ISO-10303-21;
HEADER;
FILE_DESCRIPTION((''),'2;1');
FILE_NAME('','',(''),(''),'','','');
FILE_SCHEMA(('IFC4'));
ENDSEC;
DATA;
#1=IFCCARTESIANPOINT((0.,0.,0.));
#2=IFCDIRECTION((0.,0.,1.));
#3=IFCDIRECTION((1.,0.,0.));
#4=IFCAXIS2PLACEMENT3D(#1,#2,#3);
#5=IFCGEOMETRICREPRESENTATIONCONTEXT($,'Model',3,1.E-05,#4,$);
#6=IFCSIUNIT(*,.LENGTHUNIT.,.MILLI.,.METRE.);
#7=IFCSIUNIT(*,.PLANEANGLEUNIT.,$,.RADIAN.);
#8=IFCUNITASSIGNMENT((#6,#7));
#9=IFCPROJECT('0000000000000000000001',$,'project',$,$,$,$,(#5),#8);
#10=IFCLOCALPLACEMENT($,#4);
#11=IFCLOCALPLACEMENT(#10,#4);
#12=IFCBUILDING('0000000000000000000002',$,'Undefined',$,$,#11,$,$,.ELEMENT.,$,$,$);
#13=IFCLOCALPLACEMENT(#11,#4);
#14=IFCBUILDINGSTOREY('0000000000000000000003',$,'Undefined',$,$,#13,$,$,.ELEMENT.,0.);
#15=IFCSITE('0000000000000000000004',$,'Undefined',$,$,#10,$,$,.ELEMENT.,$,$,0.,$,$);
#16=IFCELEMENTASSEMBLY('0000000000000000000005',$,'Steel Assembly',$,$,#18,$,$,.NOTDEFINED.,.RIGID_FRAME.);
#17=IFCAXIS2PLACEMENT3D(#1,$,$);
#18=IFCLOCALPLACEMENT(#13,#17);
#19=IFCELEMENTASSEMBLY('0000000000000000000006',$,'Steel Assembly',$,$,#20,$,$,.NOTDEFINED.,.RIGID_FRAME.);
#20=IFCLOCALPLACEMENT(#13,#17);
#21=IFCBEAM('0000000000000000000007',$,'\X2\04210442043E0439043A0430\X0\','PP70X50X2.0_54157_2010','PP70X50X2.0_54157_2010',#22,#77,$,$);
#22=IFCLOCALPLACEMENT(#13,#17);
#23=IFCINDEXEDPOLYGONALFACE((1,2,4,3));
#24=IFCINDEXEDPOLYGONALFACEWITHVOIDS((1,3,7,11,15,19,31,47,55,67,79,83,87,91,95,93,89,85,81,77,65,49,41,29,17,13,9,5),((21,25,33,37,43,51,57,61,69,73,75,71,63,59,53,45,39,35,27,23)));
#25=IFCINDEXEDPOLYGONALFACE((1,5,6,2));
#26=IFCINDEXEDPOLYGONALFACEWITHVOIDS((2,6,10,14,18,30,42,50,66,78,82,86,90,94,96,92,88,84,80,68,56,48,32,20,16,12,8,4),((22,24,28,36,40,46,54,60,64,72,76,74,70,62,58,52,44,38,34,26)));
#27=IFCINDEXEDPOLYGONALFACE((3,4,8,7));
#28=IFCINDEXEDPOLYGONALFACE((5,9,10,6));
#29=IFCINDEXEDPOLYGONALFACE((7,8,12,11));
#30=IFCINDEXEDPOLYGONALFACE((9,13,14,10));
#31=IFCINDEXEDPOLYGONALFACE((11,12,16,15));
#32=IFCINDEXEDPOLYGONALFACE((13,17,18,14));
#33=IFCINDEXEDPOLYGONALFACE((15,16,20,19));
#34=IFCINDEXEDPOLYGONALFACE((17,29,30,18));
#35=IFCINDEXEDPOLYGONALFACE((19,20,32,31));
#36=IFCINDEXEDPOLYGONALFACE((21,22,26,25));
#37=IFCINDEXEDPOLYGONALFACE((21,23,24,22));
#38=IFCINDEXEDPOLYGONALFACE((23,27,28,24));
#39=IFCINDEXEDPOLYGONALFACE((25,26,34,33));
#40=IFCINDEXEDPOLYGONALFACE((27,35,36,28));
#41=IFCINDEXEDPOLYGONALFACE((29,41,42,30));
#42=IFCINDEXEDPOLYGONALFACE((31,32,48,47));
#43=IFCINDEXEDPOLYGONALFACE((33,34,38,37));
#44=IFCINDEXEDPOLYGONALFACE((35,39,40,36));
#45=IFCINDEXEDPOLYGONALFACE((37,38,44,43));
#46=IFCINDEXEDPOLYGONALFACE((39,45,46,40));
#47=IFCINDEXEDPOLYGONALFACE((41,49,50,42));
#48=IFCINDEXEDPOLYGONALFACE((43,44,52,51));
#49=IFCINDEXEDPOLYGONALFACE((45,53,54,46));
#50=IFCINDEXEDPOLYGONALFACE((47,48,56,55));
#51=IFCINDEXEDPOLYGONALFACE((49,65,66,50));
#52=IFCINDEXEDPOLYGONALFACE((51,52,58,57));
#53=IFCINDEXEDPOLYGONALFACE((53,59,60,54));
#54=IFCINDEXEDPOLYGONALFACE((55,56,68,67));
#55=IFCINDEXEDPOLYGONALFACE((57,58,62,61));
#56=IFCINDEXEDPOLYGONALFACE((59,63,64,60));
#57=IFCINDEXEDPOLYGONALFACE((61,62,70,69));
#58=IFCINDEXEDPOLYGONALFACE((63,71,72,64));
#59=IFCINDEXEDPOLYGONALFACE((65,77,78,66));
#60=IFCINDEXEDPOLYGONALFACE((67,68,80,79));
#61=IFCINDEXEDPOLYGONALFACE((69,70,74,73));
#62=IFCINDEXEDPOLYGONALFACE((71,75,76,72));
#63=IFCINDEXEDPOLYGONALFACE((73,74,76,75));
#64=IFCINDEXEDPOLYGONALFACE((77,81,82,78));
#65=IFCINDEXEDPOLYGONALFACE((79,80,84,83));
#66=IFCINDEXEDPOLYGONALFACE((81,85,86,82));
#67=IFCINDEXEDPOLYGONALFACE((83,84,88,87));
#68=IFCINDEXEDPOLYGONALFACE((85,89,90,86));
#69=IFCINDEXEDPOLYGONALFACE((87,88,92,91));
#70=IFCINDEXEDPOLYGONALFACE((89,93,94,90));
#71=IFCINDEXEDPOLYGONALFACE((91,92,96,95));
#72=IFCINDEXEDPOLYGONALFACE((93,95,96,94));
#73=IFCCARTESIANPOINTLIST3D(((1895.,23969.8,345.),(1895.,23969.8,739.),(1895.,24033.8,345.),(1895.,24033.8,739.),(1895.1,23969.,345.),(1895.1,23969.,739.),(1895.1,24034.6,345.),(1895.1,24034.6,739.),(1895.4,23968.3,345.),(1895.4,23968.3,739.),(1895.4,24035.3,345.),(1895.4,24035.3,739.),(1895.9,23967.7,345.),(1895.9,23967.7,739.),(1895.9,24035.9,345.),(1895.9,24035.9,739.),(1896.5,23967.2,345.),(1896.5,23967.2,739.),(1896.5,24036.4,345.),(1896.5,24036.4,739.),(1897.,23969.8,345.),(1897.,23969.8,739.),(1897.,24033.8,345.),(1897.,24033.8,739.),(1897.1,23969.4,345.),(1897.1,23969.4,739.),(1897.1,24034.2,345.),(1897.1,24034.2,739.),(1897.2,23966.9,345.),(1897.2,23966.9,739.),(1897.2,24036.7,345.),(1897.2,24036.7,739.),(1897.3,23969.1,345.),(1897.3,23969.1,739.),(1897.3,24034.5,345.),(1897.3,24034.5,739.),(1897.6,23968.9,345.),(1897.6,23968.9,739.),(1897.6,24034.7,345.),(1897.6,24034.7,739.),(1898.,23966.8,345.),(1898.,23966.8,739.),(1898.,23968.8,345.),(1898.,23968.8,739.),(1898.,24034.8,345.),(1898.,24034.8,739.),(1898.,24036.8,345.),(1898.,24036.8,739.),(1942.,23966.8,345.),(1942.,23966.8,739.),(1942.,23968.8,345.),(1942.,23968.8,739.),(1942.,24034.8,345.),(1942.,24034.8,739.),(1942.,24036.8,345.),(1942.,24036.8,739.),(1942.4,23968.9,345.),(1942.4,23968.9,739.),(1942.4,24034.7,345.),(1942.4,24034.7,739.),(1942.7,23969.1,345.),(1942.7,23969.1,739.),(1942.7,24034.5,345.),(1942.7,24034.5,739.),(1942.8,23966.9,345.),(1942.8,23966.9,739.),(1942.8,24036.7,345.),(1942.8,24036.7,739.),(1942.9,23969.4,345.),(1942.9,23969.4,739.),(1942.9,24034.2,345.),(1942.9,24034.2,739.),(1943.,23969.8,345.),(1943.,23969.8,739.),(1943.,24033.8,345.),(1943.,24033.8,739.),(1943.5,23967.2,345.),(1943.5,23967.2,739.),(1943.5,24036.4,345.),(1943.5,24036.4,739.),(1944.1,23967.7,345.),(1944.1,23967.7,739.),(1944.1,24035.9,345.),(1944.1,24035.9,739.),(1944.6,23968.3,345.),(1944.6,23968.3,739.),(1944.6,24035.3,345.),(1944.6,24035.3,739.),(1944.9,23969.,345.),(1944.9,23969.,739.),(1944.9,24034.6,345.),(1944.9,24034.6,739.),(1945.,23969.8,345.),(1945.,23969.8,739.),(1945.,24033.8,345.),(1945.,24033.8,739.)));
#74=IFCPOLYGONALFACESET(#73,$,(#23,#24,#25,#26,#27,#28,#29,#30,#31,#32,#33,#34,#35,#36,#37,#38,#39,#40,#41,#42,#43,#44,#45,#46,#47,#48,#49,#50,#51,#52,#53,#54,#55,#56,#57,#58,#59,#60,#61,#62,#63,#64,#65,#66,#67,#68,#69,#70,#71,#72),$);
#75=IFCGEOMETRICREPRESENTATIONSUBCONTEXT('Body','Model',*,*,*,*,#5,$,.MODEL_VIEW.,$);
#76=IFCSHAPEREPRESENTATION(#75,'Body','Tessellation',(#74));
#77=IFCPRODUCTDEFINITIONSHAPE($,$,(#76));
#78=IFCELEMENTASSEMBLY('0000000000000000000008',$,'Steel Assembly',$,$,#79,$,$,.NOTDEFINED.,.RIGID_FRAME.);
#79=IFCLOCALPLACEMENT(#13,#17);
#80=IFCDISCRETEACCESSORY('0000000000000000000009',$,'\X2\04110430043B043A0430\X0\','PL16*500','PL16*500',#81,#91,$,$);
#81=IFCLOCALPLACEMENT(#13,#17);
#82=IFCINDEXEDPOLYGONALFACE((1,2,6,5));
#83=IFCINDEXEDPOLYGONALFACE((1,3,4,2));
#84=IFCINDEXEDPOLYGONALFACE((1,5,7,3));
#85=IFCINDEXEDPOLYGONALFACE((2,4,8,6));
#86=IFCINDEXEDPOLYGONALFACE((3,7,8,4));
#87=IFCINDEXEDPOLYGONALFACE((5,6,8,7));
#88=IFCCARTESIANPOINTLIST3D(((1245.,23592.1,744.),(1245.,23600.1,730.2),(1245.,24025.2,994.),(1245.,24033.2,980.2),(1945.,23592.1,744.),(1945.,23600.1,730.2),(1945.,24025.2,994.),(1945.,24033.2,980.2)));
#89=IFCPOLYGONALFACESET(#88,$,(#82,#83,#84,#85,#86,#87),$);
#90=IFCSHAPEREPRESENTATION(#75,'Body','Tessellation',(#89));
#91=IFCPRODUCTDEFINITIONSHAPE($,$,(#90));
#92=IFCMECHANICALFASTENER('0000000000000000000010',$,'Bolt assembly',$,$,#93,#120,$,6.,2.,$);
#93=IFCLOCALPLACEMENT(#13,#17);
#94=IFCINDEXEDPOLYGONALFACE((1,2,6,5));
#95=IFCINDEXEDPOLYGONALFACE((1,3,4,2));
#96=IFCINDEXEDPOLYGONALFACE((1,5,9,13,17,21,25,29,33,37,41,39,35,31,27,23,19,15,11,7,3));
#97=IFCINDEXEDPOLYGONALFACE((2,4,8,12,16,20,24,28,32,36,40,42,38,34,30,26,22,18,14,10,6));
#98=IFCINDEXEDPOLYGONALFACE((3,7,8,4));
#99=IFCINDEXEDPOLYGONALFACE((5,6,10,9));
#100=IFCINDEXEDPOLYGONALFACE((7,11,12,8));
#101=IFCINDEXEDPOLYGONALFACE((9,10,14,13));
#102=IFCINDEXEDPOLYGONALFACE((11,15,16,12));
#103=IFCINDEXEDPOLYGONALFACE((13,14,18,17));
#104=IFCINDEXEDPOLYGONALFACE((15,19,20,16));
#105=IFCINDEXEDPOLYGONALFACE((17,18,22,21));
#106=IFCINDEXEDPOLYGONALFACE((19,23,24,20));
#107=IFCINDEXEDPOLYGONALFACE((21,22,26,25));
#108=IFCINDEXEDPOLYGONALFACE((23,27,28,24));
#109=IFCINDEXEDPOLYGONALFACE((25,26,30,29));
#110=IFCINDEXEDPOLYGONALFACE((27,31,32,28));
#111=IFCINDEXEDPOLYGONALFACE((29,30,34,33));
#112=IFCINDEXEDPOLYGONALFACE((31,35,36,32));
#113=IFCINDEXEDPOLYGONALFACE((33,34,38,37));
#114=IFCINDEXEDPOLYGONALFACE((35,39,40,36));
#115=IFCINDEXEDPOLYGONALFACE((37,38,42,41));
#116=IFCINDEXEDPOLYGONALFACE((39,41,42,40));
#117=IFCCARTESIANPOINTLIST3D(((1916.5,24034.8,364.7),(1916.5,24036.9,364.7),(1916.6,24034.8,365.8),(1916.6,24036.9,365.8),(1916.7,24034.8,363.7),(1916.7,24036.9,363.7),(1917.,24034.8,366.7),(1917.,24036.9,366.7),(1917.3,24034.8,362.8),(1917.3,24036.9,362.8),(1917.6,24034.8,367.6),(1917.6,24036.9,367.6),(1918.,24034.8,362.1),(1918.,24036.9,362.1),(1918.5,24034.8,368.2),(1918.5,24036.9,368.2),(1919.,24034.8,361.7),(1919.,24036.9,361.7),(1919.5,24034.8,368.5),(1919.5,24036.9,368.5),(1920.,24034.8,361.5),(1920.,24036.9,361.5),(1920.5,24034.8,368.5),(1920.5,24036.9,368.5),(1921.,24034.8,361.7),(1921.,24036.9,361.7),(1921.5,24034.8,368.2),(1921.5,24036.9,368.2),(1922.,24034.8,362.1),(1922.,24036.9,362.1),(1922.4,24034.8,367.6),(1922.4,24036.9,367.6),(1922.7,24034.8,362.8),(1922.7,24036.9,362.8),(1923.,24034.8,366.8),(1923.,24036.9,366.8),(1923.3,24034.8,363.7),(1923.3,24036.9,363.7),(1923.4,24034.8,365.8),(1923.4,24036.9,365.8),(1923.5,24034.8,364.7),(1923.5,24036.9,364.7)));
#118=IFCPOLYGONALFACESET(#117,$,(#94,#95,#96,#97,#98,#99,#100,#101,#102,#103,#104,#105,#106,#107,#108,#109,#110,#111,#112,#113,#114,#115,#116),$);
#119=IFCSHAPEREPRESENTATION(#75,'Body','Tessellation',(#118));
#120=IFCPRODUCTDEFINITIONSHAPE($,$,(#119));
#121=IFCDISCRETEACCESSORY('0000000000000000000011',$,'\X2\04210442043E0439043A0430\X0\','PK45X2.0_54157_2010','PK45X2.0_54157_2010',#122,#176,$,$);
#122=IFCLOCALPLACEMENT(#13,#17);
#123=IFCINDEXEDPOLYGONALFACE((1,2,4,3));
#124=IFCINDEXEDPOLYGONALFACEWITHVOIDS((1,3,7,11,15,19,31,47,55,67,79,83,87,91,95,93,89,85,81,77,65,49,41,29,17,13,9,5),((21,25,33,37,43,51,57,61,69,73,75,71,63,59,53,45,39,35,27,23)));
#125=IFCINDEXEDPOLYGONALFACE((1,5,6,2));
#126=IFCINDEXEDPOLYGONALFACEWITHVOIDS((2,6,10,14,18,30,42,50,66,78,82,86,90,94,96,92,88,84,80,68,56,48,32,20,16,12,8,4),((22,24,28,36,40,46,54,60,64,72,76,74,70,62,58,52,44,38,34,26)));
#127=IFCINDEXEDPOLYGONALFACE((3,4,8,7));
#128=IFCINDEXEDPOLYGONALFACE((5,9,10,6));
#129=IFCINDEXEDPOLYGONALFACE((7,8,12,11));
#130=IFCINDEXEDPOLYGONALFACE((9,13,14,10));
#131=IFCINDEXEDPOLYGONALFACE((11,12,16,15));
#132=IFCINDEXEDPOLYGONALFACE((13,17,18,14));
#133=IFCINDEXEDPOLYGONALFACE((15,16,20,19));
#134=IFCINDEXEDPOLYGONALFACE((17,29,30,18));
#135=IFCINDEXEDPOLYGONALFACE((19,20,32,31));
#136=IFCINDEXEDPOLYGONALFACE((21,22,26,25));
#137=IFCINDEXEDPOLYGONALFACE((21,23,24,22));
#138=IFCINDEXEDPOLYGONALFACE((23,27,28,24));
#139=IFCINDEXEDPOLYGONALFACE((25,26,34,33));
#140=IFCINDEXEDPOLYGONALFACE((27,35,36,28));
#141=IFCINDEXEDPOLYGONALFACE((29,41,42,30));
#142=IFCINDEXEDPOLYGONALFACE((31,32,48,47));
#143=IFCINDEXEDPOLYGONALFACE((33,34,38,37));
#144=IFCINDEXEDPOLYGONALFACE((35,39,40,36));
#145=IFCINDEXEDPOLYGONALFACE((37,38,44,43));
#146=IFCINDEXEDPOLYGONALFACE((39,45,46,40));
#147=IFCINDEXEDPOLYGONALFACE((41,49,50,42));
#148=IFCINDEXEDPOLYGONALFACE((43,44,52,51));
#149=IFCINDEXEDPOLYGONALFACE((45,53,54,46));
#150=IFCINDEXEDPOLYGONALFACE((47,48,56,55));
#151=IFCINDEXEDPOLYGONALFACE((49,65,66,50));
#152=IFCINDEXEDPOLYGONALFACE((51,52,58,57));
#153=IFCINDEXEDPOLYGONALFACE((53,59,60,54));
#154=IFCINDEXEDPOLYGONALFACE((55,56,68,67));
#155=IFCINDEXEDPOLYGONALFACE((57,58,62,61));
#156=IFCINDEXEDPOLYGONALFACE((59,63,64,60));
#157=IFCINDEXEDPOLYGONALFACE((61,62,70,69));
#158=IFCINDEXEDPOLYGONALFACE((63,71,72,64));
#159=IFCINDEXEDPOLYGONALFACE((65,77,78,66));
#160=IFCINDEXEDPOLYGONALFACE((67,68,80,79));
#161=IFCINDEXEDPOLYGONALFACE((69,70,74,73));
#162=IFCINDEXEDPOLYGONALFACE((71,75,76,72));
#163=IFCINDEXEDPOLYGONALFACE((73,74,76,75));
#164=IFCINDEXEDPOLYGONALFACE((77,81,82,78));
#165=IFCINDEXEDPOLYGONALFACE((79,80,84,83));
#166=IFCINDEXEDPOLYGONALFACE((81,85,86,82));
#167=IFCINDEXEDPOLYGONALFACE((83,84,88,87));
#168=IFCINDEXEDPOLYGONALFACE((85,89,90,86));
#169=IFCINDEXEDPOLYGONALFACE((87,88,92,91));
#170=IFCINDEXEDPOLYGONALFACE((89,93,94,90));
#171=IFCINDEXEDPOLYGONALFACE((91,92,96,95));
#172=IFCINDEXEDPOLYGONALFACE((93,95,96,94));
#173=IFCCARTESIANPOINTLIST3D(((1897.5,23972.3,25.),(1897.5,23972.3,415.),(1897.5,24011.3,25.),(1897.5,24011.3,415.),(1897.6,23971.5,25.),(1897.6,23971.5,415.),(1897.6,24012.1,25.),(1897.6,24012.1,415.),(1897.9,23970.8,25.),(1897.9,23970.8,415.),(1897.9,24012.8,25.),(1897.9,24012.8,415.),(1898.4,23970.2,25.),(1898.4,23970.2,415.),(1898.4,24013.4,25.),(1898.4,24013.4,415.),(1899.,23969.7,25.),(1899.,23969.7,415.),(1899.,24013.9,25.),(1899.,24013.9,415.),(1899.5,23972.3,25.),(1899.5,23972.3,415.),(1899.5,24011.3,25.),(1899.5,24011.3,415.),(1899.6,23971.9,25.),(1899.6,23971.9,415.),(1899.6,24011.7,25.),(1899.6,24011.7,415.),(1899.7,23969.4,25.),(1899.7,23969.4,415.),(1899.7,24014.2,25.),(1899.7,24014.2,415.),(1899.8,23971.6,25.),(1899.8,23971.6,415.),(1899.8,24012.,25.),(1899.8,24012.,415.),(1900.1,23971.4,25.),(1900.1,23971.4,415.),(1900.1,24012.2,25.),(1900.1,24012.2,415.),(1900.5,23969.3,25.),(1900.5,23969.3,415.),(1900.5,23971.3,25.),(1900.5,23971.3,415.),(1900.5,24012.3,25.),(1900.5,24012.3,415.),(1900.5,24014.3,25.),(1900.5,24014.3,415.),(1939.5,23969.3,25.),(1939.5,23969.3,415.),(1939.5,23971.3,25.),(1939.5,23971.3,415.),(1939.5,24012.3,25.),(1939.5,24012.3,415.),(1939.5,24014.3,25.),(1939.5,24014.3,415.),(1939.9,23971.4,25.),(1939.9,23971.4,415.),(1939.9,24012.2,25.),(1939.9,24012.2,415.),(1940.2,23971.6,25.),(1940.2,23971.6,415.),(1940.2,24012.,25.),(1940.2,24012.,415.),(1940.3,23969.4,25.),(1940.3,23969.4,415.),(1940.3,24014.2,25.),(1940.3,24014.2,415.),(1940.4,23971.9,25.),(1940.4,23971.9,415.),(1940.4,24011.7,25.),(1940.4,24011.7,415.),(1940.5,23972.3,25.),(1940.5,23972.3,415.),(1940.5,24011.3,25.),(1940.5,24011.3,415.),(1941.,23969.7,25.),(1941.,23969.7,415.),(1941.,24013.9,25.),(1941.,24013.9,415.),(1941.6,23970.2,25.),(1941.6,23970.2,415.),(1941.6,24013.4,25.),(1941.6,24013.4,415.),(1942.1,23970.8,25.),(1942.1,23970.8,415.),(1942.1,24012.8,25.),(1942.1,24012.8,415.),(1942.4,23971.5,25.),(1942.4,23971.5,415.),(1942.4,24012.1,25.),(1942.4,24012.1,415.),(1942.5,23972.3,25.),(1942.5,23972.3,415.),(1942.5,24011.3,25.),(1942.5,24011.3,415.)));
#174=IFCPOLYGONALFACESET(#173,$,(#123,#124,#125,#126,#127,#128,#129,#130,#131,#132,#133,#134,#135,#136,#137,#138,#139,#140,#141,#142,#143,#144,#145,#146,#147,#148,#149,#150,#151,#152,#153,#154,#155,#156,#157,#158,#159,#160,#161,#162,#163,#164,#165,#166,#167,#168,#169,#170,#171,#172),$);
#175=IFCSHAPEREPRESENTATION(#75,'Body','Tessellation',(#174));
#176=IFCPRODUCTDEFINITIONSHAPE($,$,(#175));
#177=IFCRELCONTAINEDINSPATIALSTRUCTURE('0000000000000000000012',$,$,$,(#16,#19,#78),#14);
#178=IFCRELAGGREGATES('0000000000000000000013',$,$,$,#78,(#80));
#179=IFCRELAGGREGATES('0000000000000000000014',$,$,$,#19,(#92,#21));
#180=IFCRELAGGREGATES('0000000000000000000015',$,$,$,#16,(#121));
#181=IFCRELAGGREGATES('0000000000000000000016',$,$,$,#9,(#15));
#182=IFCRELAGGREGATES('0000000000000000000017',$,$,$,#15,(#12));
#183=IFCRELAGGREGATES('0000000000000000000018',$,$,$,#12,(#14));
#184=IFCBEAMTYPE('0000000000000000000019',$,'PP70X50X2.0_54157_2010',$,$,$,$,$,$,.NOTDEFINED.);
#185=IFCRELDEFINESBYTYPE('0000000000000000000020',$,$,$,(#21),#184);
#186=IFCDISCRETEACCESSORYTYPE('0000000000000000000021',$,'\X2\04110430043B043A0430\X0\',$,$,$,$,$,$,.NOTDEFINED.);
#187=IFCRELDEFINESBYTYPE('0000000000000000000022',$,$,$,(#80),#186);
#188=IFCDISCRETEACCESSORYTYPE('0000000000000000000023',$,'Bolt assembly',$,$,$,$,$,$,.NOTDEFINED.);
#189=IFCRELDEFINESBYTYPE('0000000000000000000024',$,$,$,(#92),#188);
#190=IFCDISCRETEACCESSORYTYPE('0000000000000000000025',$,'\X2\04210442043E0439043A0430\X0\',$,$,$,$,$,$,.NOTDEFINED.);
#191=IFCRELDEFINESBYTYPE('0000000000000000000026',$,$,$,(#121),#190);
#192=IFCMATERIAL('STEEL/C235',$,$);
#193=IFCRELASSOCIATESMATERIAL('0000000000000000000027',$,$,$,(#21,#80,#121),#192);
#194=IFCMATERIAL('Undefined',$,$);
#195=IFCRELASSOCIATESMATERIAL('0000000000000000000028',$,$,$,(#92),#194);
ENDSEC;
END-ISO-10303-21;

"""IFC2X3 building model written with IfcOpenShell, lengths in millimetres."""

from ifc_helpers import new_model, si_unit, frame, origin_with_axes, origin_2d_with_axis, place, context, subcontext, project, spatial, polyline, hollow_rectangle, circle, outline, extrude, clip, halfspace, source, transform, mapped, material, type_object, element, aggregate, save


model = new_model("IFC2X3")

# Units and contexts
model_context = context("Model", 3, precision=1e-05, world=origin_with_axes())
body_context = subcontext(model_context, "Body", "Model", "MODEL_VIEW")
ifc_project = project(units=[si_unit("LENGTHUNIT", "METRE", prefix="MILLI"), si_unit("PLANEANGLEUNIT", "RADIAN")], contexts=[model_context])

# Site, building, storey
site_placement = place(None, origin_with_axes())
site = spatial("IfcSite", under=ifc_project, at=site_placement, Name="Undefined", CompositionType="ELEMENT", RefElevation=0.0)
building_placement = place(site_placement, origin_with_axes())
building = spatial("IfcBuilding", under=site, at=building_placement, Name="Undefined", CompositionType="ELEMENT")
storey_placement = place(building_placement, origin_with_axes())
storey = spatial("IfcBuildingStorey", under=building, at=storey_placement, Name="Undefined", CompositionType="ELEMENT", Elevation=0.0)

# Element assemblies, beam
ifc_material_1 = material(Name="STEEL/C235")
assembly_1_placement = place(storey_placement, origin_with_axes())
assembly_1 = element("IfcElementAssembly", 1, at=assembly_1_placement, inside=storey, Name="Steel Assembly", AssemblyPlace="NOTDEFINED", PredefinedType="RIGID_FRAME")
assembly_2_placement = place(storey_placement, origin_with_axes())
assembly_2 = element("IfcElementAssembly", 2, at=assembly_2_placement, inside=storey, Name="Steel Assembly", AssemblyPlace="NOTDEFINED", PredefinedType="RIGID_FRAME")
beam_type_1 = type_object("IfcBeamType", Name="PP70X50X2.0_54157_2010", PredefinedType="NOTDEFINED")
beam_1_placement = place(assembly_2_placement, frame((1920.0, 24001.8, 739.0), z_axis=(0.0, -1.0, 0.0), x_axis=(0.0, 0.0, -1.0)))
beam_1 = element("IfcBeam", 3, at=beam_1_placement, type_object=beam_type_1, material=ifc_material_1, Name="Стойка", Description="PP70X50X2.0_54157_2010", ObjectType="PP70X50X2.0_54157_2010", context=body_context, shape_type="SweptSolid", body=[
    extrude(hollow_rectangle(XDim=50.0, YDim=70.0, WallThickness=2.0, InnerFilletRadius=1.0, OuterFilletRadius=3.0, at=origin_2d_with_axis()), frame((394.0, 0.0, 0.0), z_axis=(-1.0, 0.0, 0.0), x_axis=(0.0, -1.0, 0.0)), (0.0, 0.0, 1.0), 394.0),
])

# Element assembly, discrete accessory
discrete_accessory_type_1 = type_object("IfcDiscreteAccessoryType", Name="Балка")
assembly_3_placement = place(storey_placement, origin_with_axes())
assembly_3 = element("IfcElementAssembly", 4, at=assembly_3_placement, inside=storey, Name="Steel Assembly", AssemblyPlace="NOTDEFINED", PredefinedType="RIGID_FRAME")
discrete_accessory_1_placement = place(assembly_3_placement, frame((1245.0, 23812.7, 862.1), z_axis=(0.0, 0.5, -0.866025), x_axis=(1.0, 0.0, 0.0)))
discrete_accessory_1 = element("IfcDiscreteAccessory", 5, at=discrete_accessory_1_placement, type_object=discrete_accessory_type_1, material=ifc_material_1, Name="Балка", Description="PL16*500", ObjectType="PL16*500", context=body_context, shape_type="SweptSolid", body=[
    extrude(outline(polyline([(0.0, 250.0), (700.0, 250.0), (700.0, -250.0), (0.0, -250.0), (0.0, 250.0)])), frame((0.0, 0.0, -8.0), z_axis=(0.0, 0.0, 1.0), x_axis=(1.0, 0.0, 0.0)), (0.0, 0.0, 1.0), 16.0),
])
aggregate(assembly_3, [discrete_accessory_1])

# Mechanical fastener
ifc_material_2 = material(Name="Undefined")
discrete_accessory_type_2 = type_object("IfcDiscreteAccessoryType", Name="Bolt assembly")
shared_shape = source(origin_with_axes(), body_context, "Body", "SweptSolid", [
    extrude(circle(Radius=3.5, at=origin_2d_with_axis()), frame((0.0, -2.0, 0.0), z_axis=(0.0, 1.0, 0.0), x_axis=(1.0, 0.0, 0.0)), (0.0, 0.0, 1.0), 2.1),
])
mechanical_fastener_placement = place(assembly_2_placement, frame((1920.0, 24036.8, 365.0), z_axis=(1.0, 0.0, 0.0), x_axis=(0.0, 0.0, -1.0)))
mechanical_fastener = element("IfcMechanicalFastener", 6, at=mechanical_fastener_placement, type_object=discrete_accessory_type_2, material=ifc_material_2, Name="Bolt assembly", NominalDiameter=6.0, NominalLength=2.0, context=body_context, shape_type="MappedRepresentation", body=[
    mapped(shared_shape, transform((0.0, 0.0, 0.0))),
])
aggregate(assembly_2, [mechanical_fastener, beam_1])

# Discrete accessory
discrete_accessory_type_3 = type_object("IfcDiscreteAccessoryType", Name="Стойка")
discrete_accessory_2_placement = place(assembly_1_placement, frame((1920.0, 23991.8, 415.0), z_axis=(-1.0, 0.0, 0.0), x_axis=(0.0, 0.0, -1.0)))
discrete_accessory_2 = element("IfcDiscreteAccessory", 7, at=discrete_accessory_2_placement, type_object=discrete_accessory_type_3, material=ifc_material_1, Name="Стойка", Description="PK45X2.0_54157_2010", ObjectType="PK45X2.0_54157_2010", context=body_context, shape_type="Clipping", body=[
    clip(extrude(hollow_rectangle(XDim=45.0, YDim=45.0, WallThickness=2.0, InnerFilletRadius=1.0, OuterFilletRadius=3.0, at=origin_2d_with_axis()), frame((390.0, 0.0, 0.0), z_axis=(-1.0, 0.0, 0.0), x_axis=(0.0, -1.0, 0.0)), (0.0, 0.0, 1.0), 390.0), halfspace(frame((390.0, -37.5, 0.0), z_axis=(1.0, 0.0, 0.0), x_axis=(0.0, 0.0, 1.0)), False)),
])
aggregate(assembly_1, [discrete_accessory_2])

save(model, "model.ifc")
